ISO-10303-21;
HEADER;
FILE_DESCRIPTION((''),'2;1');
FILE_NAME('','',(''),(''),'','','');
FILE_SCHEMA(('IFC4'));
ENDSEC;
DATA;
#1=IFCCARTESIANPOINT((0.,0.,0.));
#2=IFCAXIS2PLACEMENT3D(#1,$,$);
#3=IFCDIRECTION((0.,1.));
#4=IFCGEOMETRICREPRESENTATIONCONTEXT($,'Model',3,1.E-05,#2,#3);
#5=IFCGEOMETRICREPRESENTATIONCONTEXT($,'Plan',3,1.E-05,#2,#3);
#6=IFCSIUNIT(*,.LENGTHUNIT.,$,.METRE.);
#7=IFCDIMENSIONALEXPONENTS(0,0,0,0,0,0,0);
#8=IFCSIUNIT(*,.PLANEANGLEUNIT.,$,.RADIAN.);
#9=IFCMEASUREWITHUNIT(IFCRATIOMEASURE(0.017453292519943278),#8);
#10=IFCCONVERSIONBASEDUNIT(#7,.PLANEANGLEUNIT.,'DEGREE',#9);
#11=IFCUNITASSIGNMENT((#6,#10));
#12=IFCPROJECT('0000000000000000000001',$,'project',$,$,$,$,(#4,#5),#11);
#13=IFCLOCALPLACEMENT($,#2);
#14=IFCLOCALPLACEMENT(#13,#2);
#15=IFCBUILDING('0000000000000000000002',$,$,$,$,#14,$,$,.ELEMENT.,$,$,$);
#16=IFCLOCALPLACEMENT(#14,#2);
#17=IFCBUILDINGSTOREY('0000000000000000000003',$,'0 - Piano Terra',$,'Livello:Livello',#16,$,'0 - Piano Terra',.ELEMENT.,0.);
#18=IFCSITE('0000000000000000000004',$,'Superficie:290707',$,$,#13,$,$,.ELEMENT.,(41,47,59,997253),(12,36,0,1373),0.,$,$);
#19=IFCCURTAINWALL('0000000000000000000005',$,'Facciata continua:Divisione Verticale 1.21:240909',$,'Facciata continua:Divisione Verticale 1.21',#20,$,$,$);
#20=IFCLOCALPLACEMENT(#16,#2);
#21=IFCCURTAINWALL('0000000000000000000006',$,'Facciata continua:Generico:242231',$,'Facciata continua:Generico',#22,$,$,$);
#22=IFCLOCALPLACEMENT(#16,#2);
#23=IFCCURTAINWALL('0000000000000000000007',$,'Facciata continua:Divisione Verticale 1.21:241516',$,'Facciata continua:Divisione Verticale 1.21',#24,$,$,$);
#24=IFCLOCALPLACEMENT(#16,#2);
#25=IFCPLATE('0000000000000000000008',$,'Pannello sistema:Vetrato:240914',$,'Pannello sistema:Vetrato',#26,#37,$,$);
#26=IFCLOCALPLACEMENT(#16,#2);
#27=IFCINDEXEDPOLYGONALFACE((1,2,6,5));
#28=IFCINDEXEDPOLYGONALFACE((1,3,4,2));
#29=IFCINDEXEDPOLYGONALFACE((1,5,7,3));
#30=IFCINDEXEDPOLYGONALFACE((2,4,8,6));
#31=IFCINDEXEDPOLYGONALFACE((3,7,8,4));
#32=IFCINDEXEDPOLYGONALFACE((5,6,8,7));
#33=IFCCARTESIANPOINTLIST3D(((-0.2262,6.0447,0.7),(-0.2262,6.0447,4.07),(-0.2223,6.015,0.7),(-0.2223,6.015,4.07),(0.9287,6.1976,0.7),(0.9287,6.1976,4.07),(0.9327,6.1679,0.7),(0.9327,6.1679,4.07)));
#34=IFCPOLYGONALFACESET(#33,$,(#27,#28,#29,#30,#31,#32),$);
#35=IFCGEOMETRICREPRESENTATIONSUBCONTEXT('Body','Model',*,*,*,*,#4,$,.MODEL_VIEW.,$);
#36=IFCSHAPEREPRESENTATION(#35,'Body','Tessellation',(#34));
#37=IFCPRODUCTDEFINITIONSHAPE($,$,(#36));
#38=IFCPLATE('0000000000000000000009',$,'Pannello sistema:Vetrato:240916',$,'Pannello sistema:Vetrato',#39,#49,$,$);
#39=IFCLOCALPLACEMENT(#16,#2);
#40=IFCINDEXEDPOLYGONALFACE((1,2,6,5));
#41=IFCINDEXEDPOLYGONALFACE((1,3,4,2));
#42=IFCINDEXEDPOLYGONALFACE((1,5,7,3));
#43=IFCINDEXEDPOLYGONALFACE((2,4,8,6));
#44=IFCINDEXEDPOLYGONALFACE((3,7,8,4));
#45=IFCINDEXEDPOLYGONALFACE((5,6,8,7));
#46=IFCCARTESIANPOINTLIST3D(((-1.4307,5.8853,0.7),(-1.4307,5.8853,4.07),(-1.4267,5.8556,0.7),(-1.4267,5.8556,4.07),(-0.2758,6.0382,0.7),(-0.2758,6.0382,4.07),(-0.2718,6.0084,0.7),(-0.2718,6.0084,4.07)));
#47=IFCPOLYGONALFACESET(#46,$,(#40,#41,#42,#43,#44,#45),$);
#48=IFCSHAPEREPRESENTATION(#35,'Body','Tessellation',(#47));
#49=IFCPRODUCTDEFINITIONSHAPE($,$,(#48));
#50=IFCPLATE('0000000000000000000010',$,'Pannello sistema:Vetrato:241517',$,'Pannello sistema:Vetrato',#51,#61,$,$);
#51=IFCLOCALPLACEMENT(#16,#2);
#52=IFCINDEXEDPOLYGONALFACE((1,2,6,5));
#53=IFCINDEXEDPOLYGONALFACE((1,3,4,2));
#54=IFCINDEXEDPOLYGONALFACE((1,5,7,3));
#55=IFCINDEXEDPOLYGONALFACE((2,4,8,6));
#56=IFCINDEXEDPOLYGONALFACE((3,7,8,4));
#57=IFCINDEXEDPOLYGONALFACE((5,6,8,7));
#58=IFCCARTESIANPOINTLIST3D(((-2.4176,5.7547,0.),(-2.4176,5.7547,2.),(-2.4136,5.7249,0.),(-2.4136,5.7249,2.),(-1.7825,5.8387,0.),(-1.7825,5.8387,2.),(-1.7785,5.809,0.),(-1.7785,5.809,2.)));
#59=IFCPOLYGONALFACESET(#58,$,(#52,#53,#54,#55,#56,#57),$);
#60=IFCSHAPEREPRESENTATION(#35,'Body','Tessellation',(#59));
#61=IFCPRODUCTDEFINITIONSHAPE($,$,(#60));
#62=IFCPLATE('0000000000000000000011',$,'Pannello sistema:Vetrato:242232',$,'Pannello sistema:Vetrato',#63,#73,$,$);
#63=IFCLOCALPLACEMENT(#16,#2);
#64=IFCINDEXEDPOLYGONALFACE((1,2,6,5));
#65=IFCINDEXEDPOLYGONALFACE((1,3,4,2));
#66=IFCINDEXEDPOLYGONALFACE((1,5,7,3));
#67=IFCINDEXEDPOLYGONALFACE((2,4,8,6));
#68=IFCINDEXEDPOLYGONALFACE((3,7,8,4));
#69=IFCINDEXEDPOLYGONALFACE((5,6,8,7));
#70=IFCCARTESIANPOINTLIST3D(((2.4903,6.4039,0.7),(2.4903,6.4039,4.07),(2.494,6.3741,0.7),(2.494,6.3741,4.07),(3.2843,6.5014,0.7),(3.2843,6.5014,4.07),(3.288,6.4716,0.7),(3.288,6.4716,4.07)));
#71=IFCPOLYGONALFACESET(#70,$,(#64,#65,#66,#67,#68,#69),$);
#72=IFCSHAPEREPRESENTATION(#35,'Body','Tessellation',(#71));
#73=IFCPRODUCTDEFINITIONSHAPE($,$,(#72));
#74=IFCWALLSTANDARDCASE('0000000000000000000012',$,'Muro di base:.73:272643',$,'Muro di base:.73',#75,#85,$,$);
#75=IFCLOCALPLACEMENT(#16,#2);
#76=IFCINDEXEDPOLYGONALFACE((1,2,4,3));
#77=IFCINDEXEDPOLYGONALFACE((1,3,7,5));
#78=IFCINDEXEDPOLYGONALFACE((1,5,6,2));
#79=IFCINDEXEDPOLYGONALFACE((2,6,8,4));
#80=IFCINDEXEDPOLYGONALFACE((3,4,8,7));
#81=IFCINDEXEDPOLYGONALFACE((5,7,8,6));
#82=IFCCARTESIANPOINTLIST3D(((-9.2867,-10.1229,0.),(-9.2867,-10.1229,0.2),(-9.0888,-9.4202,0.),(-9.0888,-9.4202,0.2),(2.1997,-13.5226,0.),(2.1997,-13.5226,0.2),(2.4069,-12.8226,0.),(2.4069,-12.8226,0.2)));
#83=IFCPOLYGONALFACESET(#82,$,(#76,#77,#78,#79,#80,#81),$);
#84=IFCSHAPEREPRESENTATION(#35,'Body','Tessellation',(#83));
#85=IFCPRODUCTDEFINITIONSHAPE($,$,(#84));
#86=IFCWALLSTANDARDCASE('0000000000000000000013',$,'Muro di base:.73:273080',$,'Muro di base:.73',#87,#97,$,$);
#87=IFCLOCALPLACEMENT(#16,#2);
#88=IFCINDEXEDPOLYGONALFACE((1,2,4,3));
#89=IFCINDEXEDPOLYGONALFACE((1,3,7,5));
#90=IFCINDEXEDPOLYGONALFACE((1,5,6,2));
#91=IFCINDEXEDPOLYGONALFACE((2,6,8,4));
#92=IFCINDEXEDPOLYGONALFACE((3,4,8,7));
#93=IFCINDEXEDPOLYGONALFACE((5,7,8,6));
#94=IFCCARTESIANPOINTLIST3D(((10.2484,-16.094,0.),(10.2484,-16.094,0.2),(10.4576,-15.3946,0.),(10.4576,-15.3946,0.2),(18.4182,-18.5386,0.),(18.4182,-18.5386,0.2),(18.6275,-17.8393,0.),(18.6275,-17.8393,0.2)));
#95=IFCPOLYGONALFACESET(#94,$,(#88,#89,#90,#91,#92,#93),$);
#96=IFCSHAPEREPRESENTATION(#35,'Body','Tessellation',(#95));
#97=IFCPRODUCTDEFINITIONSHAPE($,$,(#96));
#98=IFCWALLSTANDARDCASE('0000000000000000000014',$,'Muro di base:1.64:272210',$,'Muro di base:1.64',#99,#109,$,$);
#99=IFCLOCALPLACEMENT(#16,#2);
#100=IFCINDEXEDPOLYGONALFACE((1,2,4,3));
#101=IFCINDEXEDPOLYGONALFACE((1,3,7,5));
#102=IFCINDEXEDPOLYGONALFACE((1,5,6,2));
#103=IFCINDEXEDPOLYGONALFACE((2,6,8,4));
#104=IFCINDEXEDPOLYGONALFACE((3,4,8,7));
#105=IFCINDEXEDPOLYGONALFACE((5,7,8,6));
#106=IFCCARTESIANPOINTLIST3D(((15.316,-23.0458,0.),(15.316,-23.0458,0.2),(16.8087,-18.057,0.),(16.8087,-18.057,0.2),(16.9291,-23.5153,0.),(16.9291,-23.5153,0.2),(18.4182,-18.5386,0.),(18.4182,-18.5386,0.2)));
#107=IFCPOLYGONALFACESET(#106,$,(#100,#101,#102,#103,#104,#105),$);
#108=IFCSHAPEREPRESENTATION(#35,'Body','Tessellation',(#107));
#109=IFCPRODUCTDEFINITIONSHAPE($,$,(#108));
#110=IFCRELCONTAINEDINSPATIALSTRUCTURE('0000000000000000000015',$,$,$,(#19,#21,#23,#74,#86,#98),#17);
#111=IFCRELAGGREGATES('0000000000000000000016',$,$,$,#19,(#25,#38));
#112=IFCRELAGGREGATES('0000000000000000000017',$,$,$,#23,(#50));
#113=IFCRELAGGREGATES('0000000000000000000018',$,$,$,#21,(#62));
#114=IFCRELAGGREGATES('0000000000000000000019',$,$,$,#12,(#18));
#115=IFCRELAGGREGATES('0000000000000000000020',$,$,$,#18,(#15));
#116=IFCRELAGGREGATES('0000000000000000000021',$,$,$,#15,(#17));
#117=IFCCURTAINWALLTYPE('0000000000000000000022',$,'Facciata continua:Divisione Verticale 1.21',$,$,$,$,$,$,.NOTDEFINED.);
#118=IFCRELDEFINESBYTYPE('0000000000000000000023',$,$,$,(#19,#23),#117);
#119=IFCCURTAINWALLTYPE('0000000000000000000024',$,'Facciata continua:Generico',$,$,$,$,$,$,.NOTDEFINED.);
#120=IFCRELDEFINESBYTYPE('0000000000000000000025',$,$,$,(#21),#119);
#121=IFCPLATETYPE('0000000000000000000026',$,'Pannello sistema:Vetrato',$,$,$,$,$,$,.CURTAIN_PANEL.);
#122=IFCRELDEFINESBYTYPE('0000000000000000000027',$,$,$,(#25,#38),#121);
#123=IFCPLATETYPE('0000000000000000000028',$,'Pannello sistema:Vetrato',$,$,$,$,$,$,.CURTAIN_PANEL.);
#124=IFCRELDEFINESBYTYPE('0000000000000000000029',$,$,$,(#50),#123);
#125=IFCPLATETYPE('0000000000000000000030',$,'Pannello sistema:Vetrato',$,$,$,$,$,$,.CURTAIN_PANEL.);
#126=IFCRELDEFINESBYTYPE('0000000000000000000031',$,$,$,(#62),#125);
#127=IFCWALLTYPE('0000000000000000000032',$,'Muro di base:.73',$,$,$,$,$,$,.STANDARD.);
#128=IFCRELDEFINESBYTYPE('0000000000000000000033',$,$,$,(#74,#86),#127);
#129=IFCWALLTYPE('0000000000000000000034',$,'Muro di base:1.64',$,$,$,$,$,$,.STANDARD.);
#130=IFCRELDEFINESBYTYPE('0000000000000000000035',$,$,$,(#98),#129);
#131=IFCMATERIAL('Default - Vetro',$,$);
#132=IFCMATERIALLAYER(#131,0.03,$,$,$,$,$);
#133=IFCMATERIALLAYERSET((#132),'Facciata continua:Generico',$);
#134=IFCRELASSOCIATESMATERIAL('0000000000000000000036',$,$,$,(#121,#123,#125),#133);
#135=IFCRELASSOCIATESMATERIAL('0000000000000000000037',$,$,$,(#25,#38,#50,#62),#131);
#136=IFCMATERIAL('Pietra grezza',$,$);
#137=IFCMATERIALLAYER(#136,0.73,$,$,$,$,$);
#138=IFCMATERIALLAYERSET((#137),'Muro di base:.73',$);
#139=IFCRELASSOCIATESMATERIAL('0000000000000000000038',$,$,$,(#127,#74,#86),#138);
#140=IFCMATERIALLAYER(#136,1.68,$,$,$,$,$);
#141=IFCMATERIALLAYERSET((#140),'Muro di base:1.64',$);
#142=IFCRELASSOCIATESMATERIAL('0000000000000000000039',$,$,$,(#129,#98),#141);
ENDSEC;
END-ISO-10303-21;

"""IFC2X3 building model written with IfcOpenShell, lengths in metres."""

from ifc_helpers import new_model, entity, si_unit, converted_unit, direction, frame, frame_2d, origin, origin_2d_with_axis, place, context, subcontext, project, spatial, polyline, rectangle, outline, extrude, source, transform, mapped, material, layer, layer_set, layer_usage, type_object, type_shapes, element, aggregate, save


model = new_model("IFC2X3")

# Units and contexts
model_context = context("Model", 3, precision=1e-05, world=origin(), true_north=direction((0.0, 1.0)))
plan_context = context("Plan", 3, precision=1e-05, world=origin(), true_north=direction((0.0, 1.0)))
body_context = subcontext(model_context, "Body", "Model", "MODEL_VIEW")
ifc_project = project(units=[si_unit("LENGTHUNIT", "METRE"), converted_unit("PLANEANGLEUNIT", "DEGREE", entity("IfcRatioMeasure", 0.017453292519943278), si_unit("PLANEANGLEUNIT", "RADIAN"), dimensions=[0, 0, 0, 0, 0, 0, 0])], contexts=[model_context, plan_context])

# Site, building, storey
site_placement = place(None, origin())
site = spatial("IfcSite", under=ifc_project, at=site_placement, Name="Superficie:290707", CompositionType="ELEMENT", RefLatitude=(41, 47, 59, 997253), RefLongitude=(12, 36, 0, 1373), RefElevation=0.0)
building_placement = place(site_placement, origin())
building = spatial("IfcBuilding", under=site, at=building_placement, CompositionType="ELEMENT")
storey_placement = place(building_placement, origin())
storey = spatial("IfcBuildingStorey", under=building, at=storey_placement, Name="0 - Piano Terra", ObjectType="Livello:Livello", LongName="0 - Piano Terra", CompositionType="ELEMENT", Elevation=0.0)

# Curtain walls
curtain_wall_type_1 = type_object("IfcCurtainWallType", Name="Facciata continua:Divisione Verticale 1.21", PredefinedType="NOTDEFINED")
curtain_wall_1_placement = place(storey_placement, origin())
curtain_wall_1 = element("IfcCurtainWall", 1, at=curtain_wall_1_placement, inside=storey, type_object=curtain_wall_type_1, Name="Facciata continua:Divisione Verticale 1.21:240909", ObjectType="Facciata continua:Divisione Verticale 1.21")
curtain_wall_type_2 = type_object("IfcCurtainWallType", Name="Facciata continua:Generico", PredefinedType="NOTDEFINED")
curtain_wall_2_placement = place(storey_placement, origin())
curtain_wall_2 = element("IfcCurtainWall", 2, at=curtain_wall_2_placement, inside=storey, type_object=curtain_wall_type_2, Name="Facciata continua:Generico:242231", ObjectType="Facciata continua:Generico")

# Curtain wall
curtain_wall_3_placement = place(storey_placement, origin())
curtain_wall_3 = element("IfcCurtainWall", 3, at=curtain_wall_3_placement, inside=storey, type_object=curtain_wall_type_1, Name="Facciata continua:Divisione Verticale 1.21:241516", ObjectType="Facciata continua:Divisione Verticale 1.21")

# Shared definitions
ifc_material_1 = material(Name="Default - Vetro")
ifc_layer_1 = layer(ifc_material_1, 0.03)
ifc_layer_set_1 = layer_set([ifc_layer_1], Name="Facciata continua:Generico")

# Plates
plate_type_1 = type_object("IfcPlateType", Name="Pannello sistema:Vetrato", PredefinedType="CURTAIN_PANEL", material=ifc_layer_set_1)
shared_shape_1 = source(origin(), body_context, "Body", "SweptSolid", [
    extrude(rectangle(XDim=0.03, YDim=1.165, at=origin_2d_with_axis()), frame((0.0, 0.0, 0.0), z_axis=(0.0, 0.0, 1.0), x_axis=(0.0, 1.0, 0.0)), (0.0, 0.0, 1.0), 3.37),
])
type_shapes(plate_type_1, [shared_shape_1])
plate_1_placement = place(curtain_wall_1_placement, frame((0.3532, 6.1063, 0.7), z_axis=(0.0, 0.0, 1.0), x_axis=(-0.991352, -0.13123, 0.0)))
plate_1 = element("IfcPlate", 4, at=plate_1_placement, type_object=plate_type_1, material=ifc_material_1, Name="Pannello sistema:Vetrato:240914", ObjectType="Pannello sistema:Vetrato", context=body_context, shape_type="MappedRepresentation", body=[
    mapped(shared_shape_1, transform((0.0, 0.0, 0.0), scale=1.0)),
])
plate_2_placement = place(curtain_wall_1_placement, frame((-0.8513, 5.9469, 0.7), z_axis=(0.0, 0.0, 1.0), x_axis=(-0.991352, -0.13123, 0.0)))
plate_2 = element("IfcPlate", 5, at=plate_2_placement, type_object=plate_type_1, material=ifc_material_1, Name="Pannello sistema:Vetrato:240916", ObjectType="Pannello sistema:Vetrato", context=body_context, shape_type="MappedRepresentation", body=[
    mapped(shared_shape_1, transform((0.0, 0.0, 0.0), scale=1.0)),
])
aggregate(curtain_wall_1, [plate_1, plate_2])
plate_type_2 = type_object("IfcPlateType", Name="Pannello sistema:Vetrato", PredefinedType="CURTAIN_PANEL", material=ifc_layer_set_1)
shared_shape_2 = source(origin(), body_context, "Body", "SweptSolid", [
    extrude(rectangle(XDim=0.03, YDim=0.6406, at=frame_2d((0.0, 0.0), x_axis=(1.0, 0.0))), frame((0.0, 0.0, 0.0), z_axis=(0.0, 0.0, 1.0), x_axis=(0.0, 1.0, 0.0)), (0.0, 0.0, 1.0), 2.0),
])
type_shapes(plate_type_2, [shared_shape_2])
plate_3_placement = place(curtain_wall_3_placement, frame((-2.098, 5.7818, 0.0), z_axis=(0.0, 0.0, 1.0), x_axis=(-0.991352, -0.13123, 0.0)))
plate_3 = element("IfcPlate", 6, at=plate_3_placement, type_object=plate_type_2, material=ifc_material_1, Name="Pannello sistema:Vetrato:241517", ObjectType="Pannello sistema:Vetrato", context=body_context, shape_type="MappedRepresentation", body=[
    mapped(shared_shape_2, transform((0.0, 0.0, 0.0), scale=1.0)),
])
aggregate(curtain_wall_3, [plate_3])
plate_type_3 = type_object("IfcPlateType", Name="Pannello sistema:Vetrato", PredefinedType="CURTAIN_PANEL", material=ifc_layer_set_1)
shared_shape_3 = source(origin(), body_context, "Body", "SweptSolid", [
    extrude(rectangle(XDim=0.03, YDim=0.8, at=frame_2d((0.0, 0.0), x_axis=(1.0, 0.0))), frame((0.0, 0.0, 0.0), z_axis=(0.0, 0.0, 1.0), x_axis=(0.0, 1.0, 0.0)), (0.0, 0.0, 1.0), 3.37),
])
type_shapes(plate_type_3, [shared_shape_3])
plate_4_placement = place(curtain_wall_2_placement, frame((2.8892, 6.4377, 0.7), z_axis=(0.0, 0.0, 1.0), x_axis=(0.992546, 0.121869, 0.0)))
plate_4 = element("IfcPlate", 7, at=plate_4_placement, type_object=plate_type_3, material=ifc_material_1, Name="Pannello sistema:Vetrato:242232", ObjectType="Pannello sistema:Vetrato", context=body_context, shape_type="MappedRepresentation", body=[
    mapped(shared_shape_3, transform((0.0, 0.0, 0.0), scale=1.0)),
])
aggregate(curtain_wall_2, [plate_4])

# Walls
ifc_material_2 = material(Name="Pietra grezza")
ifc_layer_2 = layer(ifc_material_2, 0.73)
ifc_layer_set_2 = layer_set([ifc_layer_2], Name="Muro di base:.73")
ifc_layer_usage_1 = layer_usage(ifc_layer_set_2, "AXIS2", "NEGATIVE", 0.365)
wall_type_1 = type_object("IfcWallType", Name="Muro di base:.73", PredefinedType="STANDARD", material=ifc_layer_set_2)
wall_1_placement = place(storey_placement, frame((-9.1924, -9.7702, 0.0), z_axis=(0.0, 0.0, 1.0), x_axis=(0.958882, -0.283805, 0.0)))
element("IfcWallStandardCase", 8, at=wall_1_placement, inside=storey, type_object=wall_type_1, material=ifc_layer_usage_1, Name="Muro di base:.73:272643", ObjectType="Muro di base:.73", context=body_context, shape_type="SweptSolid", body=[
    extrude(outline(polyline([(11.9886, -0.365), (11.9886, 0.365), (0.0, 0.365), (0.0096, -0.365), (11.9886, -0.365)])), origin(), (0.0, 0.0, 1.0), 0.2),
])
wall_2_placement = place(storey_placement, frame((10.353, -15.7443, 0.0), z_axis=(0.0, 0.0, 1.0), x_axis=(0.95803, -0.286666, 0.0)))
element("IfcWallStandardCase", 9, at=wall_2_placement, inside=storey, type_object=wall_type_1, material=ifc_layer_usage_1, Name="Muro di base:.73:273080", ObjectType="Muro di base:.73", context=body_context, shape_type="SweptSolid", body=[
    extrude(rectangle(XDim=8.5277, YDim=0.73, at=frame_2d((4.2639, 0.0), x_axis=(-1.0, 0.0))), origin(), (0.0, 0.0, 1.0), 0.2),
])
ifc_layer_3 = layer(ifc_material_2, 1.68)
ifc_layer_set_3 = layer_set([ifc_layer_3], Name="Muro di base:1.64")
ifc_layer_usage_2 = layer_usage(ifc_layer_set_3, "AXIS2", "NEGATIVE", 0.84)
wall_type_2 = type_object("IfcWallType", Name="Muro di base:1.64", PredefinedType="STANDARD", material=ifc_layer_set_3)
wall_3_placement = place(storey_placement, frame((17.6135, -18.2978, 0.0), z_axis=(0.0, 0.0, 1.0), x_axis=(-0.286666, -0.95803, 0.0)))
element("IfcWallStandardCase", 10, at=wall_3_placement, inside=storey, type_object=wall_type_2, material=ifc_layer_usage_2, Name="Muro di base:1.64:272210", ObjectType="Muro di base:1.64", context=body_context, shape_type="SweptSolid", body=[
    extrude(outline(polyline([(5.2073, -0.84), (5.1947, 0.84), (0.0, 0.84), (0.0, -0.84), (5.2073, -0.84)])), origin(), (0.0, 0.0, 1.0), 0.2),
])

save(model, "model.ifc")
